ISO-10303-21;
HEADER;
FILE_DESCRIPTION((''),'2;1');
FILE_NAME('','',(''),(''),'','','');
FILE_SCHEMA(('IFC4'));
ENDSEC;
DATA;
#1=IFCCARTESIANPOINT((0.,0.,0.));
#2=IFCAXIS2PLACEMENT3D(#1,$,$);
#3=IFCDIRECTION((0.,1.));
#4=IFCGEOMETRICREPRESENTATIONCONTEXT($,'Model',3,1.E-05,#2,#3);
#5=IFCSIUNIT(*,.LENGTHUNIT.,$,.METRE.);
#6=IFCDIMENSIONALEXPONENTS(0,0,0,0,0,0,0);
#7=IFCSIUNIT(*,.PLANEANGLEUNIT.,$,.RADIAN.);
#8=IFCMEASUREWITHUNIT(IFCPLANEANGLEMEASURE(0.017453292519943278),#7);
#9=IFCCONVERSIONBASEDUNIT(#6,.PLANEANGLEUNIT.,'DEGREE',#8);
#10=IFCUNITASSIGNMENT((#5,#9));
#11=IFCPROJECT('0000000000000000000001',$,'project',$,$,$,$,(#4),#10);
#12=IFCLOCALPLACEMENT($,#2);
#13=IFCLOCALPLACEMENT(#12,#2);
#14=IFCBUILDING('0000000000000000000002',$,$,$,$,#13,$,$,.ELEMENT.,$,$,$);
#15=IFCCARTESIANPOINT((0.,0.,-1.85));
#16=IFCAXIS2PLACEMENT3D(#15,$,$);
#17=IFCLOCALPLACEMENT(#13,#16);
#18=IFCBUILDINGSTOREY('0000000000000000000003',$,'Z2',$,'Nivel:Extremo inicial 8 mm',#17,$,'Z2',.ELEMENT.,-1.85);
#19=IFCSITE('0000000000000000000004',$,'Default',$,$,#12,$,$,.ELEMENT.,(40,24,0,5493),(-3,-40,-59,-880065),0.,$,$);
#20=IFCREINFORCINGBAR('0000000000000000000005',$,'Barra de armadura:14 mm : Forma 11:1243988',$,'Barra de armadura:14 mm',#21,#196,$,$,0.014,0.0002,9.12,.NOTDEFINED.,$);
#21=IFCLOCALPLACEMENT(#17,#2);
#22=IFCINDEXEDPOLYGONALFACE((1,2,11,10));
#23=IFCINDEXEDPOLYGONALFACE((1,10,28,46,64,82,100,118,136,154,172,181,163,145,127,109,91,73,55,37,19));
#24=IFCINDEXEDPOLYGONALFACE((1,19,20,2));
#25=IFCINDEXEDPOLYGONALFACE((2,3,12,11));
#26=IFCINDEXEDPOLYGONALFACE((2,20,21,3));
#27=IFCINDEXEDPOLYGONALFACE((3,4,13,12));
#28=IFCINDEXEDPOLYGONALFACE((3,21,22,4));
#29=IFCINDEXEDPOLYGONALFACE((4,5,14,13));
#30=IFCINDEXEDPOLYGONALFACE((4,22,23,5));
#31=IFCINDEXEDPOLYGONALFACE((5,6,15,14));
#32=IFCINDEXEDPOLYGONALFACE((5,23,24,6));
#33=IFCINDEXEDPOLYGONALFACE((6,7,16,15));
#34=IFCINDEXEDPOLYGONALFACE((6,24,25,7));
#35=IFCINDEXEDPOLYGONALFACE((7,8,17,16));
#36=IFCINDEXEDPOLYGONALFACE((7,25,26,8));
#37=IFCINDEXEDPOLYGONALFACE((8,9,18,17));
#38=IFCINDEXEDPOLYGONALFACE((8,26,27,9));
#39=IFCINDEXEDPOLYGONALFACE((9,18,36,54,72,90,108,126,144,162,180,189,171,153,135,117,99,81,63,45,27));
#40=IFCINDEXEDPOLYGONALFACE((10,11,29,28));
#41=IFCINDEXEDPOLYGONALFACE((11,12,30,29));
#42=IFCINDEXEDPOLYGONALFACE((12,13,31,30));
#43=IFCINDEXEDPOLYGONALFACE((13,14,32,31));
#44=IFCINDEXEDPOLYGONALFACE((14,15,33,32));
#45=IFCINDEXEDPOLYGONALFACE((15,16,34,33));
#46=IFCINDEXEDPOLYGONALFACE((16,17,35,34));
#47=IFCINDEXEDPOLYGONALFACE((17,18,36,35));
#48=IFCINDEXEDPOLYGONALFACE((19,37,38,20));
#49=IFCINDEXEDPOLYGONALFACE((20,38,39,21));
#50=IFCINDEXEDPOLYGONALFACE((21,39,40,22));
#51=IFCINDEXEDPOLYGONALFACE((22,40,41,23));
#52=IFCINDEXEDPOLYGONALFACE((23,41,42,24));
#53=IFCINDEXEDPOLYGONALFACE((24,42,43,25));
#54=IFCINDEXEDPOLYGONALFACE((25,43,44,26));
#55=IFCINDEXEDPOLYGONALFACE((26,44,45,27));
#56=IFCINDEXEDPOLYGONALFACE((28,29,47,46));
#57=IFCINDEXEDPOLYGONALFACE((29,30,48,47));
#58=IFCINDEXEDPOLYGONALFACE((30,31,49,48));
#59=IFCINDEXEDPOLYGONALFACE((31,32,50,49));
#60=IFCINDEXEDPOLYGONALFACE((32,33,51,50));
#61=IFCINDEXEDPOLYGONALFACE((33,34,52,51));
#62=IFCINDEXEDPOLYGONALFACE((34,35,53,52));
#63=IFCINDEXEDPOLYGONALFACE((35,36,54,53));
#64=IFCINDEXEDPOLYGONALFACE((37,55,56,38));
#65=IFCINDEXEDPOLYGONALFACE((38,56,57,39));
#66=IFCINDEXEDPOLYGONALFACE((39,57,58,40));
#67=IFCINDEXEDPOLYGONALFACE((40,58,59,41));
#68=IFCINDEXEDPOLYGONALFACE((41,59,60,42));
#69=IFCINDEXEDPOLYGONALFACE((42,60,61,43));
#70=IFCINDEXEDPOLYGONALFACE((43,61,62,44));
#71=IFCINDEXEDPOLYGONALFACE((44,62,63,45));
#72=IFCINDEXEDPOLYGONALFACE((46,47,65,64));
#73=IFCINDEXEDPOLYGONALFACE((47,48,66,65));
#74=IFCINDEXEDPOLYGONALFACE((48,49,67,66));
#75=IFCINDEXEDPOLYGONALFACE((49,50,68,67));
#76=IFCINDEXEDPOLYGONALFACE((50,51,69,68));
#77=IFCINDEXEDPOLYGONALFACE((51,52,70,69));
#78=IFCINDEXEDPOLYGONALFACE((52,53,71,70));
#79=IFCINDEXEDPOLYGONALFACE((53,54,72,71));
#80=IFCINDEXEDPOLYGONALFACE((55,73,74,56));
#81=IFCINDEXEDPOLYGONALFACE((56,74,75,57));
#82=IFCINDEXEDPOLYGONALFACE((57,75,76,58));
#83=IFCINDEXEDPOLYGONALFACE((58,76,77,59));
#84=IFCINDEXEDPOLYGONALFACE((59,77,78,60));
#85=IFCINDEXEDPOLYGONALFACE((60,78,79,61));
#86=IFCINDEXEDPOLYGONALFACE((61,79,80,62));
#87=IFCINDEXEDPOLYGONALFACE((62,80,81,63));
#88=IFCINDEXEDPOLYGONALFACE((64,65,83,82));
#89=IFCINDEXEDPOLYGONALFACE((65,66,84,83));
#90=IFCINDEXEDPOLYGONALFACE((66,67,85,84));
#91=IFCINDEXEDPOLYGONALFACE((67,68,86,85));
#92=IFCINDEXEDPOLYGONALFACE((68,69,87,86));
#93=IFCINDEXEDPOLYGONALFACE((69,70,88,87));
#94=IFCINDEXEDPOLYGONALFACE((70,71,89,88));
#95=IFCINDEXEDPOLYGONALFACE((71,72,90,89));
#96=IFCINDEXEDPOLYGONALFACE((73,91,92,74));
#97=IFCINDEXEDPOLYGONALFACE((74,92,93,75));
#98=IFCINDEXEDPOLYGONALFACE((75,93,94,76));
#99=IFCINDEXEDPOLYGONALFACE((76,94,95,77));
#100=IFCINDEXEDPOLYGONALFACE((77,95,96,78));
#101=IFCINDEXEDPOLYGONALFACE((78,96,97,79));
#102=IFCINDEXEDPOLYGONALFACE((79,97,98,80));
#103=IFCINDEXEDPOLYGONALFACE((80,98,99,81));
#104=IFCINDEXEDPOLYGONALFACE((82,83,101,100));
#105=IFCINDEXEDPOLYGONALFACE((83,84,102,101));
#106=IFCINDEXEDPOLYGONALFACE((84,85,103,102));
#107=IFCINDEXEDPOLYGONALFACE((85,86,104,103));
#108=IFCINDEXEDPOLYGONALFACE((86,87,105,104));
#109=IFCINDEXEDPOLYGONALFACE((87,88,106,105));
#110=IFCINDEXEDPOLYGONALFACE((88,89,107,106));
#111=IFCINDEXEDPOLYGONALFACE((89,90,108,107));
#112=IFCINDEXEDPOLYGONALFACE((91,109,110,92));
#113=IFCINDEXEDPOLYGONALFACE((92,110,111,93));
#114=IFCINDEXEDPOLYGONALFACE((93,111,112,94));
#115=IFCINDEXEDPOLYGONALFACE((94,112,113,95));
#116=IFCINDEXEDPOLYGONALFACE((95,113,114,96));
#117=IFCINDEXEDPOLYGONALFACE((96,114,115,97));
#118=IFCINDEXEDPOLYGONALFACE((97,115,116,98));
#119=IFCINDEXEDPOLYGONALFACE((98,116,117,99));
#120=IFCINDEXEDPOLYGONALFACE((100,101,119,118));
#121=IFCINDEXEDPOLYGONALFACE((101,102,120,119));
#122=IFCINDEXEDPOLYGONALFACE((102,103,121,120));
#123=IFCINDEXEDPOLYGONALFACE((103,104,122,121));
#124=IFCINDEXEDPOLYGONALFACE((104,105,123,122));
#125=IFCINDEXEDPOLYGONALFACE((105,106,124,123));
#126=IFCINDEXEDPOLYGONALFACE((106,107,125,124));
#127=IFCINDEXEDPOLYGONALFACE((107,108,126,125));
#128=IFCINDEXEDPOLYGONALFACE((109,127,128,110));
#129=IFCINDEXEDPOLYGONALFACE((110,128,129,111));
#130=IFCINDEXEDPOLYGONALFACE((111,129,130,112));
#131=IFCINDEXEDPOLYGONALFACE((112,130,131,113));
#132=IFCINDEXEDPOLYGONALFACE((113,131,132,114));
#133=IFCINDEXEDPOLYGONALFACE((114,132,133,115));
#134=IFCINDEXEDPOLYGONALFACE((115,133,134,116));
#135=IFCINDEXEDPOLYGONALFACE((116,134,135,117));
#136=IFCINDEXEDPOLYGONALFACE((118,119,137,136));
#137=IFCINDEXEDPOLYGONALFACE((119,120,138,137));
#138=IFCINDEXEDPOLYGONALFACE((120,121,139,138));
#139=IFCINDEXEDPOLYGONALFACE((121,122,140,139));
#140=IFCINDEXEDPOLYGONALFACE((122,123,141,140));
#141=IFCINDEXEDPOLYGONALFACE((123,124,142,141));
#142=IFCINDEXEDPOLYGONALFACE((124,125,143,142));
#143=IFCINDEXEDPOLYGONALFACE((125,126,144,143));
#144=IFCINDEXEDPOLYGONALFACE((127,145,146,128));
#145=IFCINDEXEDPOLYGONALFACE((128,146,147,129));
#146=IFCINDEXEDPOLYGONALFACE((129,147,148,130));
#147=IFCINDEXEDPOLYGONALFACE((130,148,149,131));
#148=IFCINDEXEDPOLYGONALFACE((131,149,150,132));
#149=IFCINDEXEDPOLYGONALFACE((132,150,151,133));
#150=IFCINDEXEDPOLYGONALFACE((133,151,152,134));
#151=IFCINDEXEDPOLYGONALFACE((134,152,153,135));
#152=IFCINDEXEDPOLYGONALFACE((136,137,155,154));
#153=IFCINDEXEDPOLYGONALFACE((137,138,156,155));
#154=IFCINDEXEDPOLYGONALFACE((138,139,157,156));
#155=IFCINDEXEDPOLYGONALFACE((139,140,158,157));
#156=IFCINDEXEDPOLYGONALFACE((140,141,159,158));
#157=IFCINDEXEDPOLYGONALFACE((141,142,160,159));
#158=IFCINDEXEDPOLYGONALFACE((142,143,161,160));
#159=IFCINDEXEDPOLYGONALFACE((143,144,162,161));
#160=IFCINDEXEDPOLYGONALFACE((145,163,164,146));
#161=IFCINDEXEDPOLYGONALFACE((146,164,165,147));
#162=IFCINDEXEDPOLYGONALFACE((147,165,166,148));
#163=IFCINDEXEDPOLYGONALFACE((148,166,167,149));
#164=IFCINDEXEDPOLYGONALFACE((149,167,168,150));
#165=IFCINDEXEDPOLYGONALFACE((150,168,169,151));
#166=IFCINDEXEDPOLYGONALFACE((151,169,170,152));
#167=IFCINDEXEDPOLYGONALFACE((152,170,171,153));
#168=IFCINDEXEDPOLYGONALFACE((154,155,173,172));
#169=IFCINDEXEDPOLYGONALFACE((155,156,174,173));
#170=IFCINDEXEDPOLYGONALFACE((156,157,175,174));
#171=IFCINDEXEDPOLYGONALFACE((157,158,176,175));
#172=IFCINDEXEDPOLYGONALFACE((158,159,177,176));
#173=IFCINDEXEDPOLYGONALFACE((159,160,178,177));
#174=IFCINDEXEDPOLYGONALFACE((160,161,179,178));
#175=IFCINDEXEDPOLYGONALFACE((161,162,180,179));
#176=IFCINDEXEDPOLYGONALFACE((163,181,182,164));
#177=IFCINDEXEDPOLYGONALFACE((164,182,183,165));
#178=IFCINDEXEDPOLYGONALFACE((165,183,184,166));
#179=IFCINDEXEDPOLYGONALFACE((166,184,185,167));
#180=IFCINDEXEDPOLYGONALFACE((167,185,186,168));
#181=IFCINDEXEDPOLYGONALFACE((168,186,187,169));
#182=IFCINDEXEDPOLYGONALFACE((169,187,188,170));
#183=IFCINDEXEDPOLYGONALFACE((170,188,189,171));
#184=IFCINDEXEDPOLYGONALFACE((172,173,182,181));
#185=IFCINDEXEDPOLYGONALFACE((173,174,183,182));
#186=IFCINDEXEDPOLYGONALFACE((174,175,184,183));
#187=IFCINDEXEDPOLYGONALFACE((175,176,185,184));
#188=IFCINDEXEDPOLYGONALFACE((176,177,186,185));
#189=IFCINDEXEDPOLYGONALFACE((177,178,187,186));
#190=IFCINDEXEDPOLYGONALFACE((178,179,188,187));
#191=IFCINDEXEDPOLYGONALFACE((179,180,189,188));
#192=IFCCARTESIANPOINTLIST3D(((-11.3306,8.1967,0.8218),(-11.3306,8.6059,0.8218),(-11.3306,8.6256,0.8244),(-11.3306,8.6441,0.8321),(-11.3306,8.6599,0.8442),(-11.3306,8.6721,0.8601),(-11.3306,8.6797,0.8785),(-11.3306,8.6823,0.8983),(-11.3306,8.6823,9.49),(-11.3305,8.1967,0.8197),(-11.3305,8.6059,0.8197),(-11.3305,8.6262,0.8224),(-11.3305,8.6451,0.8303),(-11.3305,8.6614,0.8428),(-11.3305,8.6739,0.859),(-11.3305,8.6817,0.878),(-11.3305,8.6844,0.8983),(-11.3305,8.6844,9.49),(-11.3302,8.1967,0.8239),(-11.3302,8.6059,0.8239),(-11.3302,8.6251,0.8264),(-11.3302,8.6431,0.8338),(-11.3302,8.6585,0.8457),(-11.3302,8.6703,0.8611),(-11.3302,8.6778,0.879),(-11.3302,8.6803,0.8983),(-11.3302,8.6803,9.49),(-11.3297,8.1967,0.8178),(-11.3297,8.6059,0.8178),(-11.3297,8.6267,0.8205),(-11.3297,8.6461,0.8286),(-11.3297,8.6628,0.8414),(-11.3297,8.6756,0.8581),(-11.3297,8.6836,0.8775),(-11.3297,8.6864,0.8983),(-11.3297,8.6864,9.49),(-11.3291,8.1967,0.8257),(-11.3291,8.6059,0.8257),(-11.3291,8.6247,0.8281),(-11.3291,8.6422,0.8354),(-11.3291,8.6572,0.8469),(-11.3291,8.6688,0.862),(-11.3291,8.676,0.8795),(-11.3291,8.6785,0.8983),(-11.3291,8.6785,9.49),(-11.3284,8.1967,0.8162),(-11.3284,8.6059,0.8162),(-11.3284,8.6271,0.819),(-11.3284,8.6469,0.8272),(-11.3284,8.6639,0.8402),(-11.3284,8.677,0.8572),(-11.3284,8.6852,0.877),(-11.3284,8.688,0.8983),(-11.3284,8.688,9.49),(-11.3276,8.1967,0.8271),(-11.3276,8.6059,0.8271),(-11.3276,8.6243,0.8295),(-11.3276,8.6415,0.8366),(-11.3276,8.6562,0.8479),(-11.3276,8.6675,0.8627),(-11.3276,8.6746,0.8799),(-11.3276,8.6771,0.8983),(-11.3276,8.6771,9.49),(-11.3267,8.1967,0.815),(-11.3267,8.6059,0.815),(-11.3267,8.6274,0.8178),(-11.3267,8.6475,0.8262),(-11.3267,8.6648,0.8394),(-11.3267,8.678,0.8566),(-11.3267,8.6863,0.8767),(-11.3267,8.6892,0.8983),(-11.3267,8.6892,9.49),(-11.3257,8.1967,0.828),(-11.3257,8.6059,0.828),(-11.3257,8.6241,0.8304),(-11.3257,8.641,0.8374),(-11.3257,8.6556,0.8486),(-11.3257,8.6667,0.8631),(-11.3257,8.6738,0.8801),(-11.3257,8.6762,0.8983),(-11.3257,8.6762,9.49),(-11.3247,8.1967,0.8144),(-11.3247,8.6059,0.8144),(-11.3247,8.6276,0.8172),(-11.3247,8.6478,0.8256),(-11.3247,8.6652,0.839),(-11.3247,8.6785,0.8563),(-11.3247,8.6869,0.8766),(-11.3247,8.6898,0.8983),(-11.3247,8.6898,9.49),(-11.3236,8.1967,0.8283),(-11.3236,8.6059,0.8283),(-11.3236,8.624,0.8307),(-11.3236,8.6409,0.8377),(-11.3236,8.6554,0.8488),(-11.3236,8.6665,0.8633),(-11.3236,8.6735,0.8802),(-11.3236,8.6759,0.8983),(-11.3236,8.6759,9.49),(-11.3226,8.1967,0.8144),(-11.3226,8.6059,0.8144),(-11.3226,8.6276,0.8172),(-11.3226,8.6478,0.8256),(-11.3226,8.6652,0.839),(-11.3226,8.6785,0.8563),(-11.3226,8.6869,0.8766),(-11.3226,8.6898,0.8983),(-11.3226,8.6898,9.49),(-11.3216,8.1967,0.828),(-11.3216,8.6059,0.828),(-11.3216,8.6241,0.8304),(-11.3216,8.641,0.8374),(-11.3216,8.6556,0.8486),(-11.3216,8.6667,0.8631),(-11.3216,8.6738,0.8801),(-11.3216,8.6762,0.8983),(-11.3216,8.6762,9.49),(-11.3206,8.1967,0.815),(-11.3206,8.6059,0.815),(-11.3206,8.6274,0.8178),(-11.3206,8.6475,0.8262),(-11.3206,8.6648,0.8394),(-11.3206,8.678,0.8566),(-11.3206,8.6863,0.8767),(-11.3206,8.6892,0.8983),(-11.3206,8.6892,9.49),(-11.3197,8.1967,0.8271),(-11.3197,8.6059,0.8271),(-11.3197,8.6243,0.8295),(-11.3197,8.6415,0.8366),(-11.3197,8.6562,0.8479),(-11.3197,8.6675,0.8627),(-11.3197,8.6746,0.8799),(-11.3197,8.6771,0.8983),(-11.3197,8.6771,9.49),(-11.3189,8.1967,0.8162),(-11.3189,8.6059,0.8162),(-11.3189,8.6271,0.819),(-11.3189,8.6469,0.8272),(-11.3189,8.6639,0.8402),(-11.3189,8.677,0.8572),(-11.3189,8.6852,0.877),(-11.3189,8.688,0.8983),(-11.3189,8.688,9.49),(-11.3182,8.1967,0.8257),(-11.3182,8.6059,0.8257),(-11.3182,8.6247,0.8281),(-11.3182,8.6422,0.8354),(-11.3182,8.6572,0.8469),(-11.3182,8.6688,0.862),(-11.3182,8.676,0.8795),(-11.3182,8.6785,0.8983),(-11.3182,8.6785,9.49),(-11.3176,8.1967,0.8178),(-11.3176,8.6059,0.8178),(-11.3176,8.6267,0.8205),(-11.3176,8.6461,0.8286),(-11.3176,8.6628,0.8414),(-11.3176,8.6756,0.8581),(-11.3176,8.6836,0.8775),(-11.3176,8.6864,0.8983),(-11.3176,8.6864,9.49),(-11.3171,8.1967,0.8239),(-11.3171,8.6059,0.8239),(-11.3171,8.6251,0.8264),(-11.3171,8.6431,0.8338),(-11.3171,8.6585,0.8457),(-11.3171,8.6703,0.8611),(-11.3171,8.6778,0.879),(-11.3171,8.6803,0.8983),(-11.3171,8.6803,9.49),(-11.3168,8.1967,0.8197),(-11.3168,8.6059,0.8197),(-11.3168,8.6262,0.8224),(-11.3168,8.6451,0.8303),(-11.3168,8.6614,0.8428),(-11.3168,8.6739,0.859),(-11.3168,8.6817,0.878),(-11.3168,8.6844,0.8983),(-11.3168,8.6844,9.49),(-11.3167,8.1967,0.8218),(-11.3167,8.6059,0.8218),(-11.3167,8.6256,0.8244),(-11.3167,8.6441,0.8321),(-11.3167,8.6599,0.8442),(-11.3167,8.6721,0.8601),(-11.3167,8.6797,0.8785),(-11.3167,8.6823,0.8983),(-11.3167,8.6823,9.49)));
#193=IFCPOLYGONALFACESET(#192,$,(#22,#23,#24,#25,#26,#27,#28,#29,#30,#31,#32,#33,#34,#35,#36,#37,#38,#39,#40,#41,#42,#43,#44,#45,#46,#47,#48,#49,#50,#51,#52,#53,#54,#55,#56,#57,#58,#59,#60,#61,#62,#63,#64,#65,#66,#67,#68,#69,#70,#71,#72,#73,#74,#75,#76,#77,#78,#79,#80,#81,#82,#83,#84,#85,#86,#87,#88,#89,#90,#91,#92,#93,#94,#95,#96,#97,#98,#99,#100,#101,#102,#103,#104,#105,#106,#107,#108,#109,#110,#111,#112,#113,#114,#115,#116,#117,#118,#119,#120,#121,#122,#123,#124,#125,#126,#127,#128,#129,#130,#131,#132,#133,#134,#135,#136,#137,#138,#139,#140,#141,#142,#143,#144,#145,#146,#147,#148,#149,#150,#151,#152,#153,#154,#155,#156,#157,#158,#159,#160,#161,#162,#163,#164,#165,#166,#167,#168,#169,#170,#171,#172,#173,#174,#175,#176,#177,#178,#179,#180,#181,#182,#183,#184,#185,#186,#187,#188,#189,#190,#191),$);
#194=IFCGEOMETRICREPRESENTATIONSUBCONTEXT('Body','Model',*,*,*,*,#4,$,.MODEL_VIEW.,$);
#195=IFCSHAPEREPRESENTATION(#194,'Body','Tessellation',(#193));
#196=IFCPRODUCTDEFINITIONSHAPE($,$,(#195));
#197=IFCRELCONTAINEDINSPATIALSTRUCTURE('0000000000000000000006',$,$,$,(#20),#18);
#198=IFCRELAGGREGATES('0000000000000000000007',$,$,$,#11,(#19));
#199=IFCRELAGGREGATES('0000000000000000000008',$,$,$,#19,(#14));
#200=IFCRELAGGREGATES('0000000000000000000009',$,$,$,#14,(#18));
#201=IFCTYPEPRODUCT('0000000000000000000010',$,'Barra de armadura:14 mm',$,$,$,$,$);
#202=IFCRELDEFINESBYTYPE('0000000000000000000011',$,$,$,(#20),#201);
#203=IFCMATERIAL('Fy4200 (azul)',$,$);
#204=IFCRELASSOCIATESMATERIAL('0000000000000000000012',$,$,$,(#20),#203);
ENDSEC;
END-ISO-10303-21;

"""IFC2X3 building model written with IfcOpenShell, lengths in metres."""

from ifc_helpers import new_model, entity, si_unit, converted_unit, direction, frame, origin, place, context, subcontext, project, spatial, material, type_object, element, save


model = new_model("IFC2X3")

# Units and contexts
model_context = context("Model", 3, precision=1e-05, world=origin(), true_north=direction((0.0, 1.0)))
body_context = subcontext(model_context, "Body", "Model", "MODEL_VIEW")
ifc_project = project(units=[si_unit("LENGTHUNIT", "METRE"), converted_unit("PLANEANGLEUNIT", "DEGREE", entity("IfcPlaneAngleMeasure", 0.017453292519943278), si_unit("PLANEANGLEUNIT", "RADIAN"), dimensions=[0, 0, 0, 0, 0, 0, 0])], contexts=[model_context])

# Site, building, storey
site_placement = place(None, origin())
site = spatial("IfcSite", under=ifc_project, at=site_placement, Name="Default", CompositionType="ELEMENT", RefLatitude=(40, 24, 0, 5493), RefLongitude=(-3, -40, -59, -880065), RefElevation=0.0)
building_placement = place(site_placement, origin())
building = spatial("IfcBuilding", under=site, at=building_placement, CompositionType="ELEMENT")
storey_placement = place(building_placement, frame((0.0, 0.0, -1.85)))
storey = spatial("IfcBuildingStorey", under=building, at=storey_placement, Name="Z2", ObjectType="Nivel:Extremo inicial 8 mm", LongName="Z2", CompositionType="ELEMENT", Elevation=-1.85)

# Reinforcing bar
ifc_material_1 = material(Name="Fy4200 (azul)")
type_product_1 = type_object("IfcTypeProduct", Name="Barra de armadura:14 mm")
reinforcing_bar_1_placement = place(storey_placement, origin())
element("IfcReinforcingBar", 1, at=reinforcing_bar_1_placement, inside=storey, type_object=type_product_1, material=ifc_material_1, Name="Barra de armadura:14 mm : Forma 11:1243988", ObjectType="Barra de armadura:14 mm", BarLength=9.12, BarRole="NOTDEFINED", CrossSectionArea=0.0002, NominalDiameter=0.014, context=body_context, shape_type="AdvancedSweptSolid", body=[
    entity("IfcSweptDiskSolid", entity("IfcCompositeCurve", [entity("IfcCompositeCurveSegment", "CONTINUOUS", True, entity("IfcPolyline", [entity("IfcCartesianPoint", [-11.3236, 8.6829, 9.49]), entity("IfcCartesianPoint", [-11.3236, 8.6829, 0.8983])])), entity("IfcCompositeCurveSegment", "CONTINUOUS", True, entity("IfcTrimmedCurve", entity("IfcCircle", entity("IfcAxis2Placement3D", entity("IfcCartesianPoint", [-11.3236, 8.6059, 0.8983]), entity("IfcDirection", [-1.0, 0.0, 0.0]), entity("IfcDirection", [0.0, 0.0, -1.0])), 0.077), [entity("IfcParameterValue", 270.0)], [entity("IfcParameterValue", 360.0)], True, "PARAMETER")), entity("IfcCompositeCurveSegment", "CONTINUOUS", True, entity("IfcPolyline", [entity("IfcCartesianPoint", [-11.3236, 8.6059, 0.8213]), entity("IfcCartesianPoint", [-11.3236, 8.1967, 0.8213])]))], False), 0.007, None, 0.0, 92.0),
])

save(model, "model.ifc")
